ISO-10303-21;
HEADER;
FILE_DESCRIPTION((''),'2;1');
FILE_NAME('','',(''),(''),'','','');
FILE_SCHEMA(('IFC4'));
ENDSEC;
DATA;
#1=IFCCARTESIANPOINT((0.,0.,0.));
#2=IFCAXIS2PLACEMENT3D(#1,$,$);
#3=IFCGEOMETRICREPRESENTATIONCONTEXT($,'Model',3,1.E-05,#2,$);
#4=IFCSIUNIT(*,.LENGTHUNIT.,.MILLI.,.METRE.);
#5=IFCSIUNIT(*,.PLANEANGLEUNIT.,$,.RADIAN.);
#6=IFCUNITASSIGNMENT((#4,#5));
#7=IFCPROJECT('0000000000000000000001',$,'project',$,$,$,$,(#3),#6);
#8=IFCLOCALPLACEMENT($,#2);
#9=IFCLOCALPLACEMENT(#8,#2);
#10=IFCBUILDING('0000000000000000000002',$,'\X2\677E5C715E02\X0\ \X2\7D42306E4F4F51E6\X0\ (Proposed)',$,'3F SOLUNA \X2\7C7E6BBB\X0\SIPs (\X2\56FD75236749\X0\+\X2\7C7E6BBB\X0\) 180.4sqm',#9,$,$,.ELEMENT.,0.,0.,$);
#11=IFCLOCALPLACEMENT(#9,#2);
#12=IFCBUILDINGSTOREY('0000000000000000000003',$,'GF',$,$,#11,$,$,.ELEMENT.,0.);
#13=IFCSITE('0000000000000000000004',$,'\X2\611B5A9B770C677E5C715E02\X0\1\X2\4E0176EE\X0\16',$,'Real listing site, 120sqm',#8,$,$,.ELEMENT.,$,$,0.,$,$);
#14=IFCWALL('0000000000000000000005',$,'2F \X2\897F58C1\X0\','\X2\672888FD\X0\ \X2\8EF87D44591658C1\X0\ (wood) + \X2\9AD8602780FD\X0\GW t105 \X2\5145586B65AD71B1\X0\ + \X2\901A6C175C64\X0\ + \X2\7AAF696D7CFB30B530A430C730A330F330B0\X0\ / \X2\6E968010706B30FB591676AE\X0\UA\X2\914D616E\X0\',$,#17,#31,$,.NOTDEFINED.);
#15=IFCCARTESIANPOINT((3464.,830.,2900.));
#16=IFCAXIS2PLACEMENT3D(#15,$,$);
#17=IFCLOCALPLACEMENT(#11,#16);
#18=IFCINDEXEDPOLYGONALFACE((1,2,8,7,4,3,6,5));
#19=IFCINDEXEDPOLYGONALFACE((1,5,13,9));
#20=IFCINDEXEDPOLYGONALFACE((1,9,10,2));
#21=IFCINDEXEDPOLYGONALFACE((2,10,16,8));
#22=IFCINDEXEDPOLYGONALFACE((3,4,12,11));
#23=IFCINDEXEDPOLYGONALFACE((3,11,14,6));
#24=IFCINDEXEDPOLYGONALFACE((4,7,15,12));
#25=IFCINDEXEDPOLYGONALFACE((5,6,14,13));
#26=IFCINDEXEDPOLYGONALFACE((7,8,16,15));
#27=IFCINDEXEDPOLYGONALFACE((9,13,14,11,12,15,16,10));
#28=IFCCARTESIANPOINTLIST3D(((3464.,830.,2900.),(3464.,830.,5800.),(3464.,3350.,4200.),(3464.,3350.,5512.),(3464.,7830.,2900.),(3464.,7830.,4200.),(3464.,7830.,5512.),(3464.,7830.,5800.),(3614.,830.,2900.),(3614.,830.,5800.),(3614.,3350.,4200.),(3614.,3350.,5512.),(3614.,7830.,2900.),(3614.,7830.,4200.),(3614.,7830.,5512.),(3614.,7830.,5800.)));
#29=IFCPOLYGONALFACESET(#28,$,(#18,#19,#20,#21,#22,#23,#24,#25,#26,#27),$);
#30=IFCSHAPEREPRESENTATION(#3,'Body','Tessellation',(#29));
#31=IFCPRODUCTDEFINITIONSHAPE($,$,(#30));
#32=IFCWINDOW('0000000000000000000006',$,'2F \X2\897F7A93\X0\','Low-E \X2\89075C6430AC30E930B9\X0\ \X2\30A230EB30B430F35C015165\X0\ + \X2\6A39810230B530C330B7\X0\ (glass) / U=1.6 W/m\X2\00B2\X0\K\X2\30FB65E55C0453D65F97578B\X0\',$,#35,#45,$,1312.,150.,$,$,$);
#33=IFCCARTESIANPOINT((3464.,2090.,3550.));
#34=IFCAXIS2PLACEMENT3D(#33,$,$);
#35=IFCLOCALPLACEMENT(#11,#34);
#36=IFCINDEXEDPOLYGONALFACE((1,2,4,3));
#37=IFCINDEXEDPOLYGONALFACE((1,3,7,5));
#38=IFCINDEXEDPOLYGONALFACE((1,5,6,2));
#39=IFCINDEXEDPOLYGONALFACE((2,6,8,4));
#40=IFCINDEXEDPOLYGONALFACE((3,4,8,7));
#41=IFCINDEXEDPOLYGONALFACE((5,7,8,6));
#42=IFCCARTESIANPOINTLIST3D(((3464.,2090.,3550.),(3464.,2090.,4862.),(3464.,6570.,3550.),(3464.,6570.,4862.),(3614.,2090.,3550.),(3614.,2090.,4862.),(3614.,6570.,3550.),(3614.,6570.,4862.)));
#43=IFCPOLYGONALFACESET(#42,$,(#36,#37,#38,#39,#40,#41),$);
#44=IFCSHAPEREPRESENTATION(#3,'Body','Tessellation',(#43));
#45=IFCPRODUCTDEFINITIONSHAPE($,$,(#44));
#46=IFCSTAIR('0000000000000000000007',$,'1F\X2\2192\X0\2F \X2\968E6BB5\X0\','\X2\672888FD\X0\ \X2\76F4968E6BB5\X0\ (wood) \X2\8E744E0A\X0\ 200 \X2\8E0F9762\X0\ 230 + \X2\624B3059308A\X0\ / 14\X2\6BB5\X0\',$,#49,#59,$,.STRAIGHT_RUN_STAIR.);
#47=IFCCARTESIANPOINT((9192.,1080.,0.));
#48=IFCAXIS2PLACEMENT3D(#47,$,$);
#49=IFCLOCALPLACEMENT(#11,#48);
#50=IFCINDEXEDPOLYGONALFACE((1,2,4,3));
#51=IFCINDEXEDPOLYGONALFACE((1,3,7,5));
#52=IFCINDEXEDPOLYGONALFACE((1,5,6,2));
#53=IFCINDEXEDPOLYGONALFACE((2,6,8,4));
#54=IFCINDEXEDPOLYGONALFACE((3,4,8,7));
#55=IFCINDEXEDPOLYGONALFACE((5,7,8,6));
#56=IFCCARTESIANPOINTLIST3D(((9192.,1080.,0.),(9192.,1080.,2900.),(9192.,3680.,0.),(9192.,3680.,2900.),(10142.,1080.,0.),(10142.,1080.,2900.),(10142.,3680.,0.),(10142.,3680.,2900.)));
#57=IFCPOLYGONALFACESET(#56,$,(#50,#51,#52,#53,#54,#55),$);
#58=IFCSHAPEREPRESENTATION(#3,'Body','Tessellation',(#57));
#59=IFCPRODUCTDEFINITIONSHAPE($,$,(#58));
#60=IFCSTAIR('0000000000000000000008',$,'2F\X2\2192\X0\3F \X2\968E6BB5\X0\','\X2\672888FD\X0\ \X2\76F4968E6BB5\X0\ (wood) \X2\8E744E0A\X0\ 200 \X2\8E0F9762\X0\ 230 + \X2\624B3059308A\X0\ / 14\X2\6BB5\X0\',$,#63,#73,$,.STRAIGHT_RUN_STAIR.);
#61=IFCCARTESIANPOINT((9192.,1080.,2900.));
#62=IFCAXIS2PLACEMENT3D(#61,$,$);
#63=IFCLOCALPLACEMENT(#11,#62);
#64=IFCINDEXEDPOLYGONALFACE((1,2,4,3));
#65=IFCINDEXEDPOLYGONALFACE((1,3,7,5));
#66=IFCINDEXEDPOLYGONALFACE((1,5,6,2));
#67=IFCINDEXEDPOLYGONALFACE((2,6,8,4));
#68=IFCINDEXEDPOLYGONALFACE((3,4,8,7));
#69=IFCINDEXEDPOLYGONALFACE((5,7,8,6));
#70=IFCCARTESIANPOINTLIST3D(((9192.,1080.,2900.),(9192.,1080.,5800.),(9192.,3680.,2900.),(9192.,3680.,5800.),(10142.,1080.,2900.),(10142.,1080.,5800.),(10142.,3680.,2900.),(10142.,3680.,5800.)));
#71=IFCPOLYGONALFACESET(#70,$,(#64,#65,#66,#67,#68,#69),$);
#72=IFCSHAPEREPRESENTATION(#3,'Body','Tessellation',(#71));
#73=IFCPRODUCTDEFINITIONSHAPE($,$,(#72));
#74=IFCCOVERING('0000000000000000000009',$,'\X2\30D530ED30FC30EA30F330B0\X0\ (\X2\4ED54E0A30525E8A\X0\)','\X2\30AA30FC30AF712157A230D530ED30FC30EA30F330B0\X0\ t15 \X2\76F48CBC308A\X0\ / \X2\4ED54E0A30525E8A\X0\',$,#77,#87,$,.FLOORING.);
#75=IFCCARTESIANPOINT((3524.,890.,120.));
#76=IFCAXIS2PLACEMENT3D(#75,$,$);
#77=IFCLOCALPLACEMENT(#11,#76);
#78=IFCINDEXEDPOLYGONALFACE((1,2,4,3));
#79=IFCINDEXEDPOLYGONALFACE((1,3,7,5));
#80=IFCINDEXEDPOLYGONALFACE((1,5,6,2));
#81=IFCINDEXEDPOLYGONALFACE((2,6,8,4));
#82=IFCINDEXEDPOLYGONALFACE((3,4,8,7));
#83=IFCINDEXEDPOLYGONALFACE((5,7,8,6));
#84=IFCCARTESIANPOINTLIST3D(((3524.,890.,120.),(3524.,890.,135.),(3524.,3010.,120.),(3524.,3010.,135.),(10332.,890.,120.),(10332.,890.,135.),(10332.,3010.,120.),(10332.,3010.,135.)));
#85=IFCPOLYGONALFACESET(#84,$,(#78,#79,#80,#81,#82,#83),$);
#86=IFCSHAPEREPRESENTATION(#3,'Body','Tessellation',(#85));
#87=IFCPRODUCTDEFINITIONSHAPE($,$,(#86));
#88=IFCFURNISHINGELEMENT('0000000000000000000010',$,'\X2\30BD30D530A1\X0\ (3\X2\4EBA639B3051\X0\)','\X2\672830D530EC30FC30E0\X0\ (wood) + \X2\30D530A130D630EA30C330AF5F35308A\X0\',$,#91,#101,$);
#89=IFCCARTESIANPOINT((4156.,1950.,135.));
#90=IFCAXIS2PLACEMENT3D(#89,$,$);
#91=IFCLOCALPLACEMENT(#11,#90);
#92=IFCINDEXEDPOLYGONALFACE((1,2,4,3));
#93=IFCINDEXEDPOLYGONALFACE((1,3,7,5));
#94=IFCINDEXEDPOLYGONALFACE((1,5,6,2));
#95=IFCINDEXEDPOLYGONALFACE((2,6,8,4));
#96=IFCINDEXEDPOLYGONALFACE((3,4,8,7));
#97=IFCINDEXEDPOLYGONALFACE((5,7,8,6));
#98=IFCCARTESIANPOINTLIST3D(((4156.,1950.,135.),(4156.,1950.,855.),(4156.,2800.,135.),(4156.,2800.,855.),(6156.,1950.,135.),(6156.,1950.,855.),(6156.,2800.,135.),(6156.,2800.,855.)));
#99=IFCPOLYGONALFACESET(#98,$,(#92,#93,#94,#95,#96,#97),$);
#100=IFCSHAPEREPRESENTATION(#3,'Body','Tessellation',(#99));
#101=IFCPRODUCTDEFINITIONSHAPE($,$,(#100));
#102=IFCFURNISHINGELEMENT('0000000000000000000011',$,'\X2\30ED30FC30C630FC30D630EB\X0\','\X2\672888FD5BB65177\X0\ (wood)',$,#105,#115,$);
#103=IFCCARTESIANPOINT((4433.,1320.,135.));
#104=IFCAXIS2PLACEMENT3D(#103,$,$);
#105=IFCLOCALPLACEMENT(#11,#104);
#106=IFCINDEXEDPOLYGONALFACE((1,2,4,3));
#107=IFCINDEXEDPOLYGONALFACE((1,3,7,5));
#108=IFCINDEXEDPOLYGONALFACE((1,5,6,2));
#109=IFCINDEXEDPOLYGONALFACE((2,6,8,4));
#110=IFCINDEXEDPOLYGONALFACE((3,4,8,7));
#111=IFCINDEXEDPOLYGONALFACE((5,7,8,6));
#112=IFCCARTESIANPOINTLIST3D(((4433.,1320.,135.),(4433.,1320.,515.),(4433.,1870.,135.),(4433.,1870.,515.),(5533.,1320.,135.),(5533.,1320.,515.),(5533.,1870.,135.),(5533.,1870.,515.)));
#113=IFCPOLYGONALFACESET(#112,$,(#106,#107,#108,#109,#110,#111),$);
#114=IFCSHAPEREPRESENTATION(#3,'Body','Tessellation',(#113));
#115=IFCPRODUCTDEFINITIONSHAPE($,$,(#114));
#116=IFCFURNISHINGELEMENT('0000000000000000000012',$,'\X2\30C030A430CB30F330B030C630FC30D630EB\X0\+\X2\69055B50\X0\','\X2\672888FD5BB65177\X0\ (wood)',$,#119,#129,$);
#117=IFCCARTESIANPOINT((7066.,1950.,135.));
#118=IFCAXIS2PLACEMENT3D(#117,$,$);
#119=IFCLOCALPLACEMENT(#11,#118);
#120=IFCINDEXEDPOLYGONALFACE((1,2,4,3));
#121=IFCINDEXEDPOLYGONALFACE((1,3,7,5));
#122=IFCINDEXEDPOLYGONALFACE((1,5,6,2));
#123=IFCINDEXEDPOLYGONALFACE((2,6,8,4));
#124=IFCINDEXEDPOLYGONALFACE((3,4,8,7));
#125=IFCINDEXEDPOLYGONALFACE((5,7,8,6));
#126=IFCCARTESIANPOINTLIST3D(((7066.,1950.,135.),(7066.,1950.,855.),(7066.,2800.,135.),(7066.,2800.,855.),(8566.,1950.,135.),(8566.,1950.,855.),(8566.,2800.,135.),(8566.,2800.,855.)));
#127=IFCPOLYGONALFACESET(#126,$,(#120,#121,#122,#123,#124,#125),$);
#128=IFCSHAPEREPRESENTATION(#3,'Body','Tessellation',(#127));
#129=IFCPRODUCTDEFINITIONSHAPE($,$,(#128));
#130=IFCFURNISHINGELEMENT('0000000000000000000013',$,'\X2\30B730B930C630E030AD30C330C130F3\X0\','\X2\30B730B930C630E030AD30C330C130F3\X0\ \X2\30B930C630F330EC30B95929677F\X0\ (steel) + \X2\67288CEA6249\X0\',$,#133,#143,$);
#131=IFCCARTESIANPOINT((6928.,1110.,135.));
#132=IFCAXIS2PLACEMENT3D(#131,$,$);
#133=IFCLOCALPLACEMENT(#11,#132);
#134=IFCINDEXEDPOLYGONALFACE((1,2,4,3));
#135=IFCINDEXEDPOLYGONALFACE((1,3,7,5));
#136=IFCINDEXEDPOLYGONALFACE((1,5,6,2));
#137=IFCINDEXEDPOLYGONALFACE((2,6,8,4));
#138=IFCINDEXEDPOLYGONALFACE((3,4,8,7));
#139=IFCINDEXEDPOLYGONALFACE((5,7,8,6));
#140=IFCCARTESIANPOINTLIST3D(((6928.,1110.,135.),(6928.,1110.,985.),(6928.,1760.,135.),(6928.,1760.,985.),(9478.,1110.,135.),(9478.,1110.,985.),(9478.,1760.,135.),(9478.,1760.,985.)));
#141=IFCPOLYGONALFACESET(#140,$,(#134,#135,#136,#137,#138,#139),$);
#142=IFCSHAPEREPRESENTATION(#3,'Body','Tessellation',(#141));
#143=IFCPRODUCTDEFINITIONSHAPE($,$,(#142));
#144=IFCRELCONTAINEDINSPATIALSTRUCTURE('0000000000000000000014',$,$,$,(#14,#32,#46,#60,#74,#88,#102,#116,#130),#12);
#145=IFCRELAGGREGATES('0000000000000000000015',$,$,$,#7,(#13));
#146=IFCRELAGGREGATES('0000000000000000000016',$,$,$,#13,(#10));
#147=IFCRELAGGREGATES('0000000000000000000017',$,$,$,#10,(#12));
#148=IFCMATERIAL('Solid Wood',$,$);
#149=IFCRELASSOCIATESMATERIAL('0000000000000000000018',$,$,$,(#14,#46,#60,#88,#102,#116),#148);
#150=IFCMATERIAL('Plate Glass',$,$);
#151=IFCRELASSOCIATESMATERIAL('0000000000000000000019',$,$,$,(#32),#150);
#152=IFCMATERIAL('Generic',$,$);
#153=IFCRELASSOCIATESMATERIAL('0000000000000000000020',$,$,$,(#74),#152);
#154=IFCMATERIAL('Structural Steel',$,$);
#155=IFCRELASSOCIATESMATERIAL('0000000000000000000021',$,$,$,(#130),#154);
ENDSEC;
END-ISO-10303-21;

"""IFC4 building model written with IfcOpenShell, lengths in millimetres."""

from ifc_helpers import new_model, si_unit, frame, frame_2d, origin, place, context, project, spatial, rectangle, extrude, material, element, fill, save


model = new_model("IFC4")

# Units and contexts
model_context = context("Model", 3, precision=1e-05, world=origin())
ifc_project = project(units=[si_unit("LENGTHUNIT", "METRE", prefix="MILLI"), si_unit("PLANEANGLEUNIT", "RADIAN")], contexts=[model_context])

# Site, building, storey
site_placement = place(None, origin())
site = spatial("IfcSite", under=ifc_project, at=site_placement, Name="愛媛県松山市1丁目16", ObjectType="Real listing site, 120sqm", CompositionType="ELEMENT", RefElevation=0.0)
building_placement = place(site_placement, origin())
building = spatial("IfcBuilding", under=site, at=building_placement, Name="松山市 終の住処 (Proposed)", ObjectType="3F SOLUNA 籾殻SIPs (国産杉+籾殻) 180.4sqm", CompositionType="ELEMENT", ElevationOfRefHeight=0.0, ElevationOfTerrain=0.0)
storey_placement = place(building_placement, origin())
storey = spatial("IfcBuildingStorey", under=building, at=storey_placement, Name="GF", CompositionType="ELEMENT", Elevation=0.0)

# Shared definitions
ifc_material_1 = material(Name="Solid Wood")

# Shared definitions
ifc_material_2 = material(Name="Plate Glass")

# Wall, opening, window
wall_1_placement = place(storey_placement, frame((3464.0, 830.0, 2900.0)))
wall_1 = element("IfcWall", 1, at=wall_1_placement, inside=storey, material=ifc_material_1, Name="2F 西壁", Description="木製 軸組外壁 (wood) + 高性能GW t105 充填断熱 + 通気層 + 窯業系サイディング / 準耐火・外皮UA配慮", PredefinedType="NOTDEFINED", context=model_context, shape_type="SweptSolid", body=[
    extrude(rectangle(XDim=150.0, YDim=7000.0, at=frame_2d((75.0, 3500.0))), frame((3464.0, 830.0, 2900.0)), (0.0, 0.0, 1.0), 2900.0),
])
opening_1_placement = place(storey_placement, frame((3464.0, 2090.0, 3550.0)))
opening_1 = element("IfcOpeningElement", 2, at=opening_1_placement, cuts=wall_1, PredefinedType="NOTDEFINED", context=model_context, shape_type="SweptSolid", body=[
    extrude(rectangle(XDim=150.0, YDim=4480.0, at=frame_2d((75.0, 2240.0))), frame((3464.0, 2090.0, 3550.0)), (0.0, 0.0, 1.0), 1312.0),
])
window_1_placement = place(storey_placement, frame((3464.0, 2090.0, 3550.0)))
window_1 = element("IfcWindow", 3, at=window_1_placement, inside=storey, material=ifc_material_2, Name="2F 西窓", Description="Low-E 複層ガラス アルゴン封入 + 樹脂サッシ (glass) / U=1.6 W/m²K・日射取得型", OverallHeight=1312.0, OverallWidth=150.0, context=model_context, shape_type="SweptSolid", body=[
    extrude(rectangle(XDim=150.0, YDim=4480.0, at=frame_2d((75.0, 2240.0))), frame((3464.0, 2090.0, 3550.0)), (0.0, 0.0, 1.0), 1312.0),
])
fill(opening_1, window_1)

# Stairs
stair_1_placement = place(storey_placement, frame((9192.0, 1080.0, 0.0)))
element("IfcStair", 4, at=stair_1_placement, inside=storey, material=ifc_material_1, Name="1F→2F 階段", Description="木製 直階段 (wood) 蹴上 200 踏面 230 + 手すり / 14段", PredefinedType="STRAIGHT_RUN_STAIR", context=model_context, shape_type="SweptSolid", body=[
    extrude(rectangle(XDim=950.0, YDim=2600.0, at=frame_2d((475.0, 1300.0))), frame((9192.0, 1080.0, 0.0)), (0.0, 0.0, 1.0), 2900.0),
])
stair_2_placement = place(storey_placement, frame((9192.0, 1080.0, 2900.0)))
element("IfcStair", 5, at=stair_2_placement, inside=storey, material=ifc_material_1, Name="2F→3F 階段", Description="木製 直階段 (wood) 蹴上 200 踏面 230 + 手すり / 14段", PredefinedType="STRAIGHT_RUN_STAIR", context=model_context, shape_type="SweptSolid", body=[
    extrude(rectangle(XDim=950.0, YDim=2600.0, at=frame_2d((475.0, 1300.0))), frame((9192.0, 1080.0, 2900.0)), (0.0, 0.0, 1.0), 2900.0),
])

# Covering
ifc_material_3 = material(Name="Generic")
covering_placement = place(storey_placement, frame((3524.0, 890.0, 120.0)))
element("IfcCovering", 6, at=covering_placement, inside=storey, material=ifc_material_3, Name="フローリング (仕上げ床)", Description="オーク無垢フローリング t15 直貼り / 仕上げ床", PredefinedType="FLOORING", context=model_context, shape_type="SweptSolid", body=[
    extrude(rectangle(XDim=6808.0, YDim=2120.0, at=frame_2d((3404.0, 1060.0))), frame((3524.0, 890.0, 120.0)), (0.0, 0.0, 1.0), 15.0),
])

# Furnishing elements
furnishing_1_placement = place(storey_placement, frame((4156.0, 1950.0, 135.0)))
element("IfcFurnishingElement", 7, at=furnishing_1_placement, inside=storey, material=ifc_material_1, Name="ソファ (3人掛け)", Description="木フレーム (wood) + ファブリック張り", context=model_context, shape_type="SweptSolid", body=[
    extrude(rectangle(XDim=2000.0, YDim=850.0, at=frame_2d((1000.0, 425.0))), frame((4156.0, 1950.0, 135.0)), (0.0, 0.0, 1.0), 720.0),
])
furnishing_2_placement = place(storey_placement, frame((4433.0, 1320.0, 135.0)))
element("IfcFurnishingElement", 8, at=furnishing_2_placement, inside=storey, material=ifc_material_1, Name="ローテーブル", Description="木製家具 (wood)", context=model_context, shape_type="SweptSolid", body=[
    extrude(rectangle(XDim=1100.0, YDim=550.0, at=frame_2d((550.0, 275.0))), frame((4433.0, 1320.0, 135.0)), (0.0, 0.0, 1.0), 380.0),
])
furnishing_3_placement = place(storey_placement, frame((7066.0, 1950.0, 135.0)))
element("IfcFurnishingElement", 9, at=furnishing_3_placement, inside=storey, material=ifc_material_1, Name="ダイニングテーブル+椅子", Description="木製家具 (wood)", context=model_context, shape_type="SweptSolid", body=[
    extrude(rectangle(XDim=1500.0, YDim=850.0, at=frame_2d((750.0, 425.0))), frame((7066.0, 1950.0, 135.0)), (0.0, 0.0, 1.0), 720.0),
])
ifc_material_4 = material(Name="Structural Steel")
furnishing_4_placement = place(storey_placement, frame((6928.0, 1110.0, 135.0)))
element("IfcFurnishingElement", 10, at=furnishing_4_placement, inside=storey, material=ifc_material_4, Name="システムキッチン", Description="システムキッチン ステンレス天板 (steel) + 木質扉", context=model_context, shape_type="SweptSolid", body=[
    extrude(rectangle(XDim=2550.0, YDim=650.0, at=frame_2d((1275.0, 325.0))), frame((6928.0, 1110.0, 135.0)), (0.0, 0.0, 1.0), 850.0),
])

save(model, "model.ifc")
